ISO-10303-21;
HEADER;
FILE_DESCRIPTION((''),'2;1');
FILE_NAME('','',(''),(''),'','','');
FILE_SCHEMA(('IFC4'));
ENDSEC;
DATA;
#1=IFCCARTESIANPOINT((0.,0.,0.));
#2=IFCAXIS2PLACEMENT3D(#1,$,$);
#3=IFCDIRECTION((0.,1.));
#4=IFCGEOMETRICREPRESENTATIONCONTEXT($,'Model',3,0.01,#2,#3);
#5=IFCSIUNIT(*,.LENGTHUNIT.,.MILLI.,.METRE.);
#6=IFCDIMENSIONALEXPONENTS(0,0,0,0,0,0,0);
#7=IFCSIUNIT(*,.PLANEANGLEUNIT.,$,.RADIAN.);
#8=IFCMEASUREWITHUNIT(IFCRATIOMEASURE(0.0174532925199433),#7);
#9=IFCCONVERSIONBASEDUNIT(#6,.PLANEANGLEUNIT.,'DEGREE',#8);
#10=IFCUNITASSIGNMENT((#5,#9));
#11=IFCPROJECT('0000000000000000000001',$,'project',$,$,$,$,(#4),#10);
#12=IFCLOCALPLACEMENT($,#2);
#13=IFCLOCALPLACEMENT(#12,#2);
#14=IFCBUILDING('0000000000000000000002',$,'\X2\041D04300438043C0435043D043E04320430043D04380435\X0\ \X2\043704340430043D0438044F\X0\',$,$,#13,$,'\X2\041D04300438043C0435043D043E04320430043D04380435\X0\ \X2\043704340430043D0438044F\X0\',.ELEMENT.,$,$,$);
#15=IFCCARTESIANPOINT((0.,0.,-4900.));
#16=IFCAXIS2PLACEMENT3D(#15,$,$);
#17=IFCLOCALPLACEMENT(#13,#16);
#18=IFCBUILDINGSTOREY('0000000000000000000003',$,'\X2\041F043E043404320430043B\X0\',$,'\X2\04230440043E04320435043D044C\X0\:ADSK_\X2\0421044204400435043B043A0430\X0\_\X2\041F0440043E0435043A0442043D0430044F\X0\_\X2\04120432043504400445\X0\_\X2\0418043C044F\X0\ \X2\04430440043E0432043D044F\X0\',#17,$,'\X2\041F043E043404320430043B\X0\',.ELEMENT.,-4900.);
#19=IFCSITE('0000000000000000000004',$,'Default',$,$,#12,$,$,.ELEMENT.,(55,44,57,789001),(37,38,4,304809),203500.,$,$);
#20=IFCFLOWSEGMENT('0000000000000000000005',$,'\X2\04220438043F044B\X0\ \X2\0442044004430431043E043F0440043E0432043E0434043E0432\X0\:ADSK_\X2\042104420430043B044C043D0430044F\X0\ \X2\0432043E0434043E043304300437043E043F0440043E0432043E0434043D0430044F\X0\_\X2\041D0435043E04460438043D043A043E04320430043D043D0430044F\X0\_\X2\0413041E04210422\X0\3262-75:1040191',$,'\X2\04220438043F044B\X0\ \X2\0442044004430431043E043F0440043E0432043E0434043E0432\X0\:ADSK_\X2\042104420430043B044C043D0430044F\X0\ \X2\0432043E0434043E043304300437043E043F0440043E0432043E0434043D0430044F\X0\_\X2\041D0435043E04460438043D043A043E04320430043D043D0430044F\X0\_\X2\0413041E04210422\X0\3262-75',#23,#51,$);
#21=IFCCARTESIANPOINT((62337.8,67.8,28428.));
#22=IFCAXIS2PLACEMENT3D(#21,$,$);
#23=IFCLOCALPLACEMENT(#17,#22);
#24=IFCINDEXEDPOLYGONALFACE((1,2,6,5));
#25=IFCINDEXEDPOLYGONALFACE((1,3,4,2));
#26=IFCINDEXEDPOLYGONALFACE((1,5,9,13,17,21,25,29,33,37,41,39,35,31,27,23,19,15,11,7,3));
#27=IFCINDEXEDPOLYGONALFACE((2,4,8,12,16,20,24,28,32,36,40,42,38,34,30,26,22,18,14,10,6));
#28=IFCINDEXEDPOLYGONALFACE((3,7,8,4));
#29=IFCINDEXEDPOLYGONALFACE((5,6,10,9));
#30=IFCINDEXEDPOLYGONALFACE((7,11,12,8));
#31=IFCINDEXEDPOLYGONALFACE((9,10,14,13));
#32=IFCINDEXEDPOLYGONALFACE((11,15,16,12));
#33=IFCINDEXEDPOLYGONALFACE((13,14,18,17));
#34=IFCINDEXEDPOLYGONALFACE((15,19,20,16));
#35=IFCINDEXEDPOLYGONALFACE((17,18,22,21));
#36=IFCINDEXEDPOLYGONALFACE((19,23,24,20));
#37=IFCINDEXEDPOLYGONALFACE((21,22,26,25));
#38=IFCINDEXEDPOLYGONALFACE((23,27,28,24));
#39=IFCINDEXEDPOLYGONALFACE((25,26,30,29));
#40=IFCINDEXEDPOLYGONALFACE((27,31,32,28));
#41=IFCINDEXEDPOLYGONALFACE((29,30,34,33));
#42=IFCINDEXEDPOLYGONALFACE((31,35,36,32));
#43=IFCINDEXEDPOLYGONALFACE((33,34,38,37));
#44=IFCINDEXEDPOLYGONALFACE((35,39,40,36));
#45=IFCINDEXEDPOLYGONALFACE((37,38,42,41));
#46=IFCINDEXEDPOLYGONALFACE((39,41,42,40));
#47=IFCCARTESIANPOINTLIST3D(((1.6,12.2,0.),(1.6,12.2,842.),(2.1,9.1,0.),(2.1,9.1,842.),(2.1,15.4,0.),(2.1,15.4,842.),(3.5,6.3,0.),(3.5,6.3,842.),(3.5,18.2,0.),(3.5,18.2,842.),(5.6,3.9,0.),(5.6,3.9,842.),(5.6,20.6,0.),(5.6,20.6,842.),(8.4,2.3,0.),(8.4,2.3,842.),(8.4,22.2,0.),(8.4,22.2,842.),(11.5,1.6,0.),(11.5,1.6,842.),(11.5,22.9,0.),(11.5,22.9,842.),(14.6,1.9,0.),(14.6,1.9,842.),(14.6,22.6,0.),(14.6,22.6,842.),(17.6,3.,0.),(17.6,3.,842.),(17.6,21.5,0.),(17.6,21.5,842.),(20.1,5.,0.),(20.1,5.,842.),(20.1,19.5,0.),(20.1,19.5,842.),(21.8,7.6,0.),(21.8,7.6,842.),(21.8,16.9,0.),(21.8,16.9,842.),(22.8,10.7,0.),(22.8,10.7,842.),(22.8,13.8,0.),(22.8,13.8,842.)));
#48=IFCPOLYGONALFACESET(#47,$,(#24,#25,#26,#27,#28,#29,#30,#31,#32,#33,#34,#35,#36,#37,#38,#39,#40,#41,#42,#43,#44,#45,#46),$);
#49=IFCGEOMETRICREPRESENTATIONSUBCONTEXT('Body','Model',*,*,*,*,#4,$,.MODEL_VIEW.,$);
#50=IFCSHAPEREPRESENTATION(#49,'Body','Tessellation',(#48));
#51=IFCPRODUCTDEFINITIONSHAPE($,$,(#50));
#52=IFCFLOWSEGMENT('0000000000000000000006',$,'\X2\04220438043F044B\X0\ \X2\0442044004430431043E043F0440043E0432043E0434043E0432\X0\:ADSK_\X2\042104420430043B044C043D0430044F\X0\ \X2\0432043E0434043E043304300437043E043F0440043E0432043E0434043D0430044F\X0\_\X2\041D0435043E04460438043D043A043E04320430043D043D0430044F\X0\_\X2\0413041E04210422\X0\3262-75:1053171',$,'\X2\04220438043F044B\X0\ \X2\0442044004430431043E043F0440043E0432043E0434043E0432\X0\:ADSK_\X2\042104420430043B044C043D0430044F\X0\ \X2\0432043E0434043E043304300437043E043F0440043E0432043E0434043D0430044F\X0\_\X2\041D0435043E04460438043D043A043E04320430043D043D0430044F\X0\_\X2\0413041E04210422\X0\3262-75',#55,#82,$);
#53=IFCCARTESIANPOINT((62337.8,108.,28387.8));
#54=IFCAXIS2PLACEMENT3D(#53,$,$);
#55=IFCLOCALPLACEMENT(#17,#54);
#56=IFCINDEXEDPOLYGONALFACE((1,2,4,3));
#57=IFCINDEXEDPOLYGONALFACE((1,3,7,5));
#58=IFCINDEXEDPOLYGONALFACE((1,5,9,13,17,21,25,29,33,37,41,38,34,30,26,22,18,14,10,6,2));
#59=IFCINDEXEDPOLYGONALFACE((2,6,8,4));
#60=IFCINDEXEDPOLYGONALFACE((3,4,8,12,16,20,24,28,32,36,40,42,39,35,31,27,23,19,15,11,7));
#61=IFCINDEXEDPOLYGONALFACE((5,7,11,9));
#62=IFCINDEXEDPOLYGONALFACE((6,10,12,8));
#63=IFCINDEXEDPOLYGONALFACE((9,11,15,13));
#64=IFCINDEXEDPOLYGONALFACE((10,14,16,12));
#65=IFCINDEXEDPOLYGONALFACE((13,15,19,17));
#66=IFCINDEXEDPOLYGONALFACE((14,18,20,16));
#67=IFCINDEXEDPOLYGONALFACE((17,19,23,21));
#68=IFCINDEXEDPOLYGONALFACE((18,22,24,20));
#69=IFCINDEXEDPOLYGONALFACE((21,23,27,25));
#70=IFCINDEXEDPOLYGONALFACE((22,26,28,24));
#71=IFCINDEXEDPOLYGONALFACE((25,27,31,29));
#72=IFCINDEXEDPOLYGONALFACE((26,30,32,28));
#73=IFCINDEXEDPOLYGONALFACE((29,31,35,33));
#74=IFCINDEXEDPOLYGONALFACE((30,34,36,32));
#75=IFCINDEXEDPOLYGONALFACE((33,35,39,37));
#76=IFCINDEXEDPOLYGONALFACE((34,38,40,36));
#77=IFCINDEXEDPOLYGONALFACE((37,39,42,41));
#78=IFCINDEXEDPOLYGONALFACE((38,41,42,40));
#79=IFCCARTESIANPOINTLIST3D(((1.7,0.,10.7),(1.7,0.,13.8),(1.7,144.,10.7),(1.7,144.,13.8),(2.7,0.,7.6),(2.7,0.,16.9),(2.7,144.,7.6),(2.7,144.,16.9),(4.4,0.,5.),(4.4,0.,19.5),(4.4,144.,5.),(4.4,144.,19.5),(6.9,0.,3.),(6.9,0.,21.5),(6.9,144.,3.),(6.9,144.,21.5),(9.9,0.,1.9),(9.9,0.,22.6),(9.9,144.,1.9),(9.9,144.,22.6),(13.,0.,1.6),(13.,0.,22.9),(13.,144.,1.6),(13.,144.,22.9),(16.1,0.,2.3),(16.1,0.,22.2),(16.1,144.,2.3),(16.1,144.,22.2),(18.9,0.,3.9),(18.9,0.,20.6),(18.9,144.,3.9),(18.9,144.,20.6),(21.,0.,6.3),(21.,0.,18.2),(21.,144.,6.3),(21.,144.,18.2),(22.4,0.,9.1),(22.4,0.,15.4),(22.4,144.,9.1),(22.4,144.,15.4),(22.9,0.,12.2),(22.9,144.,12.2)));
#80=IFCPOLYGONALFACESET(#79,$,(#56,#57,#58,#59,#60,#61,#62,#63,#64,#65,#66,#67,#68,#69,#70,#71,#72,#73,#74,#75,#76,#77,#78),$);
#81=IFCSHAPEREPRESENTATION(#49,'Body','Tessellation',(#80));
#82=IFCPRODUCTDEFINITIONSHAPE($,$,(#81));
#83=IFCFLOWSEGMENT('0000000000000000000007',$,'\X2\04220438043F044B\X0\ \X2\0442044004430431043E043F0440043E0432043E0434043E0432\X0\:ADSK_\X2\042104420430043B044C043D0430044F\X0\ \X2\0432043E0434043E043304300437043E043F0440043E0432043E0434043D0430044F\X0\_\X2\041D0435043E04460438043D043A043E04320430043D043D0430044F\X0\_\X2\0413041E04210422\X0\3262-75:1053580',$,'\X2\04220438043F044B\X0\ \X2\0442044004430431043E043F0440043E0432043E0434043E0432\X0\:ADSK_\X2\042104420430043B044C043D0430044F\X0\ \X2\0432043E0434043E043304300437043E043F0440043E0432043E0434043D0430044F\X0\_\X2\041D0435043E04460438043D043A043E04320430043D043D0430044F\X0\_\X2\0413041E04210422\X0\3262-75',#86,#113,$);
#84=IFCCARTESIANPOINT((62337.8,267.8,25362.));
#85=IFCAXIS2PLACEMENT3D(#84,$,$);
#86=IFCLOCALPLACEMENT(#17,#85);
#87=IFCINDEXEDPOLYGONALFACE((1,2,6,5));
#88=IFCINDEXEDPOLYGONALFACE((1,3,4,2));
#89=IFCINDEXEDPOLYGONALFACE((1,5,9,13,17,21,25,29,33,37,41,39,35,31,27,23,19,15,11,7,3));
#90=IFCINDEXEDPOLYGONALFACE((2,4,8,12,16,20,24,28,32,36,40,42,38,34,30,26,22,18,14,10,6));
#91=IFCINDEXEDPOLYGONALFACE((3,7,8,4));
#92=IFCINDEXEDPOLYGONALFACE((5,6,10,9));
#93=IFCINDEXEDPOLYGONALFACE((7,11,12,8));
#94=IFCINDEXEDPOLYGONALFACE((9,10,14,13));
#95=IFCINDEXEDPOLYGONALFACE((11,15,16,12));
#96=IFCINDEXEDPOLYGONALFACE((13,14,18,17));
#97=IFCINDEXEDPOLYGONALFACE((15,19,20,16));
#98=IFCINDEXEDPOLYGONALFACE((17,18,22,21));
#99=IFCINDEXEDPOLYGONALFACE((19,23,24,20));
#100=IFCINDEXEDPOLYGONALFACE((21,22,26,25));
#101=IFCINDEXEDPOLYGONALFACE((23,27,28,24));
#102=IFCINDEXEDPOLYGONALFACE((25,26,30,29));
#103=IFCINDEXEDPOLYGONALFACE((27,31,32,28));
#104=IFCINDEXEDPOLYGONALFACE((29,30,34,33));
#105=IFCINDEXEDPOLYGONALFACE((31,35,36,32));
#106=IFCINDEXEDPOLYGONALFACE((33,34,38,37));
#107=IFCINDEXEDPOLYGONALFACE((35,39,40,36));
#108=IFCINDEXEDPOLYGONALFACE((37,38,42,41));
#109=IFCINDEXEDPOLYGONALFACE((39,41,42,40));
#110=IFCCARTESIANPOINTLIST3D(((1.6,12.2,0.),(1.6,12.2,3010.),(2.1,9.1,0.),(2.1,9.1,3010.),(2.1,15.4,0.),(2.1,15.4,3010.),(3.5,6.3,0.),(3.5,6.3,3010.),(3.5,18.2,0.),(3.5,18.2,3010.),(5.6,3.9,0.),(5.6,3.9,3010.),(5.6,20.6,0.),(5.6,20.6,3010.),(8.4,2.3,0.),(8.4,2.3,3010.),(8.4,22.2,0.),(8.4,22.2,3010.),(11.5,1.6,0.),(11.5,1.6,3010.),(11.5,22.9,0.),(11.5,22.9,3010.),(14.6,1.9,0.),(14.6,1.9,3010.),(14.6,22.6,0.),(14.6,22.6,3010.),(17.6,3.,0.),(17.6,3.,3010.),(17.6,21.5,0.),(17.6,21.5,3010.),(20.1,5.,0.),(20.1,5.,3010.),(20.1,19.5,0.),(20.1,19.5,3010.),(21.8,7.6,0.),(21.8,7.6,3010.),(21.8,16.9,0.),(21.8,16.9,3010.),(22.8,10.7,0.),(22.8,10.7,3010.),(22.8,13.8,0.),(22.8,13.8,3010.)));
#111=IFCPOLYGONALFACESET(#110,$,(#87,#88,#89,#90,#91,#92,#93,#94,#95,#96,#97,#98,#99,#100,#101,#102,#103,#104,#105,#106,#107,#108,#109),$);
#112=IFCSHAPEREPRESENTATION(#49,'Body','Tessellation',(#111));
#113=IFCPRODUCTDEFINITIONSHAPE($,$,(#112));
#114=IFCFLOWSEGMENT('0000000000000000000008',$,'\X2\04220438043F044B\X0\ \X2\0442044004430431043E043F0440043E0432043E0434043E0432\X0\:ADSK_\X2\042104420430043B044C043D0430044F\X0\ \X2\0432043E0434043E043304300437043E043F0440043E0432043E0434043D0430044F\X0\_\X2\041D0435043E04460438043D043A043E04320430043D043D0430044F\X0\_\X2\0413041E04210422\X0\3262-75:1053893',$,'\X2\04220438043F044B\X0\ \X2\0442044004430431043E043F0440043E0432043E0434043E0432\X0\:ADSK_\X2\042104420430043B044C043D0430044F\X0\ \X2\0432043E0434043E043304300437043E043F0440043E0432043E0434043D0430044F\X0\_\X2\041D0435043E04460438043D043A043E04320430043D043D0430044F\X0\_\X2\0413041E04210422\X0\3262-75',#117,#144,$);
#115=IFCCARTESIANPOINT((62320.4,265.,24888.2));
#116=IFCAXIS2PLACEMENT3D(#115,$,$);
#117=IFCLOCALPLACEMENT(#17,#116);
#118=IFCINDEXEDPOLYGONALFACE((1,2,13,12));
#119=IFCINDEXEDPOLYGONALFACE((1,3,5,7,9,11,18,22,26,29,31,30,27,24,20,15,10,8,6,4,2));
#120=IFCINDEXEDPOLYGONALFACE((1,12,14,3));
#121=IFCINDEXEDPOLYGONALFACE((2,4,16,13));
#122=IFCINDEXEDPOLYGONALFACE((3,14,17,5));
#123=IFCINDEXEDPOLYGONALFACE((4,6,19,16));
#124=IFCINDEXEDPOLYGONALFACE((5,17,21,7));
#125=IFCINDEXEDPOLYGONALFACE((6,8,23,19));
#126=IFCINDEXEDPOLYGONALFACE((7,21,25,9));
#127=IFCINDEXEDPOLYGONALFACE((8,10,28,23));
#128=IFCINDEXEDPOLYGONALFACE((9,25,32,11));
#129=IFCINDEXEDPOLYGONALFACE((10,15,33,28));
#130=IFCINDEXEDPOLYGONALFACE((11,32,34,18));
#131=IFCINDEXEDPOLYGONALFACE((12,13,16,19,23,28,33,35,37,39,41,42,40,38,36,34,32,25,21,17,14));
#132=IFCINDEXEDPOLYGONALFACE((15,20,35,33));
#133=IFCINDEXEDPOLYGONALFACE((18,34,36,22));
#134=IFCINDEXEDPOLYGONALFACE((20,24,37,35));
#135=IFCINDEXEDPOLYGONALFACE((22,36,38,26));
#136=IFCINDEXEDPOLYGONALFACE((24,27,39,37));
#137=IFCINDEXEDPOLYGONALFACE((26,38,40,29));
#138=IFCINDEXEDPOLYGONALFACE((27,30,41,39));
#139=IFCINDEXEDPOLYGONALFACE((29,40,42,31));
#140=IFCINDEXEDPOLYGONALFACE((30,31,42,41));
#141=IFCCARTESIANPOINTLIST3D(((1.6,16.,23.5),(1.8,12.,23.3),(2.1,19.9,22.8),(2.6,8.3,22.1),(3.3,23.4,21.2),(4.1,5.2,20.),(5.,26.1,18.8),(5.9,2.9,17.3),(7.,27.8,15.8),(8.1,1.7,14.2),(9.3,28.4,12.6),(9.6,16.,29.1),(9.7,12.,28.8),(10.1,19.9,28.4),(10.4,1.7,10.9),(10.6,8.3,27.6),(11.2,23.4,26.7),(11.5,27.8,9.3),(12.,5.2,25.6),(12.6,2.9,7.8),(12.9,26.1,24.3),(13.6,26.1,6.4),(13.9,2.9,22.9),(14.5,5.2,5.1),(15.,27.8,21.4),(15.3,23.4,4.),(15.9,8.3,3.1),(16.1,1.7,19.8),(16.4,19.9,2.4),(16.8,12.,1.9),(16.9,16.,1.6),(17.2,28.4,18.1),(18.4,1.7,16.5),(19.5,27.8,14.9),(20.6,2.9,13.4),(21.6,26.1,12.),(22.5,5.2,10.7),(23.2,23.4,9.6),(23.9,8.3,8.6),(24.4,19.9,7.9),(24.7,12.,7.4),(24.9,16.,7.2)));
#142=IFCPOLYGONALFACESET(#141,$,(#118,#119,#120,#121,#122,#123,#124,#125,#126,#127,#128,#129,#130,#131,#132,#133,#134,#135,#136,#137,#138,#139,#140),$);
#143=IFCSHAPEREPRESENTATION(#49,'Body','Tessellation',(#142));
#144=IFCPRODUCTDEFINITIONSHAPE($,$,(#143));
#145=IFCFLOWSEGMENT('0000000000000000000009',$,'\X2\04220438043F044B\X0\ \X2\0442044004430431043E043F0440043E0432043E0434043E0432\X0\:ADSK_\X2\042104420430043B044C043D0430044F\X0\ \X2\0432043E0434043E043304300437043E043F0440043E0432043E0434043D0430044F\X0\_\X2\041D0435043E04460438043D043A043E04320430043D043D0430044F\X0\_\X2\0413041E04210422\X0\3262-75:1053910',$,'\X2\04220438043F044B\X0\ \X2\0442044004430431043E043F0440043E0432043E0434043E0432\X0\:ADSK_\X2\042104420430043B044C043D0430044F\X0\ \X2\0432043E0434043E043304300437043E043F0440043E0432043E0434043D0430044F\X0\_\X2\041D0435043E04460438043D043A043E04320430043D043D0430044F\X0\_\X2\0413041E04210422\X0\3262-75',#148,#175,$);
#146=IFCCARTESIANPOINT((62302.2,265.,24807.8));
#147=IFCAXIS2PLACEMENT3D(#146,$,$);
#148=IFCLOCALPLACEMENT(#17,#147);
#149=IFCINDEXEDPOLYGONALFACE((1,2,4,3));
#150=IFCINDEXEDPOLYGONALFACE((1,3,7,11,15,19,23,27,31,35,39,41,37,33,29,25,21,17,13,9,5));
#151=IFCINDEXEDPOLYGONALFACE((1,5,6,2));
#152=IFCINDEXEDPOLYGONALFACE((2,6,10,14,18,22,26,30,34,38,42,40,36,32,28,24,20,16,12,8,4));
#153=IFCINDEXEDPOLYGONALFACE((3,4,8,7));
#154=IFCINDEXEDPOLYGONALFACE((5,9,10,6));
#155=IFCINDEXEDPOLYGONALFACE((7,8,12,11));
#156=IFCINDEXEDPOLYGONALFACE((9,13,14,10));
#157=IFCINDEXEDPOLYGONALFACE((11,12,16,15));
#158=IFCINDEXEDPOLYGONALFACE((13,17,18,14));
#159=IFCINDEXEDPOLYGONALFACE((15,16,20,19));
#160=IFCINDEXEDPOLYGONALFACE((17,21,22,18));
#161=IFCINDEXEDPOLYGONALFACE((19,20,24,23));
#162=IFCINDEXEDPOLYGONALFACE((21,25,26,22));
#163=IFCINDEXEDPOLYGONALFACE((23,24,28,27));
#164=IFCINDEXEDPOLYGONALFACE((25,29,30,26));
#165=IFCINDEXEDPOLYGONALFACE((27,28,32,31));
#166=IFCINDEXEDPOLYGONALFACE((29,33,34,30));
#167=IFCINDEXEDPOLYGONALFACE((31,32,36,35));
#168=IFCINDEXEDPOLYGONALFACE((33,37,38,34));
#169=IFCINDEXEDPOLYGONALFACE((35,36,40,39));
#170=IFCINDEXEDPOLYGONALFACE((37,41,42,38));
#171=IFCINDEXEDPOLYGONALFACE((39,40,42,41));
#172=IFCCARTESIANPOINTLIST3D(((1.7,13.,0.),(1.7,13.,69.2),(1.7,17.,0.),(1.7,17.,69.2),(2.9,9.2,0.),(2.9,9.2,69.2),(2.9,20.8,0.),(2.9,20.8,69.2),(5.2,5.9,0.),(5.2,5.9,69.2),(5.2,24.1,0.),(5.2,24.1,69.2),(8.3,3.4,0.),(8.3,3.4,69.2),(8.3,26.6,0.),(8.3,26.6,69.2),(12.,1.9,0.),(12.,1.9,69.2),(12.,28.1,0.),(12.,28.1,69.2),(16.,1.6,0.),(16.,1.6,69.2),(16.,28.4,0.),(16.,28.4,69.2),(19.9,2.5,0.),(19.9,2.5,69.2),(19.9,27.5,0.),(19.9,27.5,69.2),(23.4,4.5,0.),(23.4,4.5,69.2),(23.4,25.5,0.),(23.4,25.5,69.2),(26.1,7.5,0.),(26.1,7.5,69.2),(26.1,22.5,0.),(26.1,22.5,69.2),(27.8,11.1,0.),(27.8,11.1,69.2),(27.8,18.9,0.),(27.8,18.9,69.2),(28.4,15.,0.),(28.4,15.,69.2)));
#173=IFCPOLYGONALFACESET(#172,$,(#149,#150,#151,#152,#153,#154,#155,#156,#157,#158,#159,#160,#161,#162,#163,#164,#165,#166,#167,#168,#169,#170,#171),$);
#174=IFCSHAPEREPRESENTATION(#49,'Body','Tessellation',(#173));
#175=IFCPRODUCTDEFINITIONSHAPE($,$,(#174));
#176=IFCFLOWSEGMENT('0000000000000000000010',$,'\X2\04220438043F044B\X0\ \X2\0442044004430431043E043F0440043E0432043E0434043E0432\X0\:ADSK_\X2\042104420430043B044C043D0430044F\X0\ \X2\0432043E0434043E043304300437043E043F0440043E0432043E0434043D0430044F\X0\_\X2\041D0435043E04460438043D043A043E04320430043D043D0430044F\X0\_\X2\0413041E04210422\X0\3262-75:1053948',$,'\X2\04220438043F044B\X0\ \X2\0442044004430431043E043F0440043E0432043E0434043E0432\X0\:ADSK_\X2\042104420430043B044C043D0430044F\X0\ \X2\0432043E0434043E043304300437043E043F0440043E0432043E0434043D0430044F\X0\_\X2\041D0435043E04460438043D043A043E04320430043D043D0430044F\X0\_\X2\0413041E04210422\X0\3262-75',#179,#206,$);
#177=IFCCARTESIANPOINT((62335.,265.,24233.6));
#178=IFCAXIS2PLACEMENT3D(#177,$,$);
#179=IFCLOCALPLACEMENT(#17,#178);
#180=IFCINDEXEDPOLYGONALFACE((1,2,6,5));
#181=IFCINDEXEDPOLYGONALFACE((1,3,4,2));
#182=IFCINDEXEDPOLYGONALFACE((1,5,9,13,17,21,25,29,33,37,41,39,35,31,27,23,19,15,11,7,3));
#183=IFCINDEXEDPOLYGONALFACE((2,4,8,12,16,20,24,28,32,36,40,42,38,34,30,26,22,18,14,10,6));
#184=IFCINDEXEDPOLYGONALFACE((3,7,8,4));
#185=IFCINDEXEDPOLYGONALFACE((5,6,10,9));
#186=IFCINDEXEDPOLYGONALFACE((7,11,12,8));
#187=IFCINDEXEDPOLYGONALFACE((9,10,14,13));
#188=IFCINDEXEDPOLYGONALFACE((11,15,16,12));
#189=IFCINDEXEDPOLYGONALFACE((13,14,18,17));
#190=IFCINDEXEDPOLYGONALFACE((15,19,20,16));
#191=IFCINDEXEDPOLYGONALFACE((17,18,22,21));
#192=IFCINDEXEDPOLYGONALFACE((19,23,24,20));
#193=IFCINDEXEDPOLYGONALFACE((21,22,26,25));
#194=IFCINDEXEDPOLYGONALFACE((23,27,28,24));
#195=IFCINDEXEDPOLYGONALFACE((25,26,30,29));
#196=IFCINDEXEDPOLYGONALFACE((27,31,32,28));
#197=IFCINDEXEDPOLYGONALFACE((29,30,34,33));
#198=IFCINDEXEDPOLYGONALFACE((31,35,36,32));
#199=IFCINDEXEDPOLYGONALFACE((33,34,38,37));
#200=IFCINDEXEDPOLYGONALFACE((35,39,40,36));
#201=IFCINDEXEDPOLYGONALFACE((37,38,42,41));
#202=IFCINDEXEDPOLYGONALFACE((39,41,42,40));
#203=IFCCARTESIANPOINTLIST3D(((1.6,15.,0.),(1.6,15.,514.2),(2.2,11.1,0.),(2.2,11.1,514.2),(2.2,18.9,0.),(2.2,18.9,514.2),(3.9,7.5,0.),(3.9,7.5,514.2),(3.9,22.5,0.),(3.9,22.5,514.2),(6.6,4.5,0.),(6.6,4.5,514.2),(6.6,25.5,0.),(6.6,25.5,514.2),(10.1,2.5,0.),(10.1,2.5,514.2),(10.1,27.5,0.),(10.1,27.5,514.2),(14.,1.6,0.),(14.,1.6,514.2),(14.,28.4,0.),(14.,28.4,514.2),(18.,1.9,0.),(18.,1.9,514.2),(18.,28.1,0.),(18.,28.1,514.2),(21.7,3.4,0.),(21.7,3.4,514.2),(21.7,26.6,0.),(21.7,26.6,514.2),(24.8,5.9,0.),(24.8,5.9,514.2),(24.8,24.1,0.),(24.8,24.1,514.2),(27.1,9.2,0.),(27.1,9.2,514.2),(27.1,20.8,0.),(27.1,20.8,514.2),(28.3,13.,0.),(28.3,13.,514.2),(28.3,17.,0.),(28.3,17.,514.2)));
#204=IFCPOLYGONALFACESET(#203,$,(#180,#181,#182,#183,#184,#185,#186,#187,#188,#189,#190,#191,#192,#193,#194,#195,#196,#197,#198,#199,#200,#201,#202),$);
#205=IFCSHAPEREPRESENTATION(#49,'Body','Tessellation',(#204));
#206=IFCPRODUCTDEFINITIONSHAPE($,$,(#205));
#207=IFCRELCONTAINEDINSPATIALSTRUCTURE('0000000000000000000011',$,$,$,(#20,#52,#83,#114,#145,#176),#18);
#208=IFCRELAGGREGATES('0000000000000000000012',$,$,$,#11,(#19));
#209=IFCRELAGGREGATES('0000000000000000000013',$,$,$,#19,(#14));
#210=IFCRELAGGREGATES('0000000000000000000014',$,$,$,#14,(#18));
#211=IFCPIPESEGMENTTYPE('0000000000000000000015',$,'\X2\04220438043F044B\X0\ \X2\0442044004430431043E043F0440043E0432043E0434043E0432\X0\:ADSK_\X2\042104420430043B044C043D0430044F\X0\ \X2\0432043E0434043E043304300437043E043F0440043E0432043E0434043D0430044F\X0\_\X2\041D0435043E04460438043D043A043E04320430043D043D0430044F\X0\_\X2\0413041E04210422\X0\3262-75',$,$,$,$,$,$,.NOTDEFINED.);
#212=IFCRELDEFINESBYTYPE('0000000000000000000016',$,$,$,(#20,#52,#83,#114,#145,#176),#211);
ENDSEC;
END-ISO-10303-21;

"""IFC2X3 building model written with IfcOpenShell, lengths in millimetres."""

from ifc_helpers import new_model, entity, si_unit, converted_unit, direction, frame, origin, origin_2d_with_axis, place, context, subcontext, project, spatial, circle, extrude, type_object, element, save


model = new_model("IFC2X3")

# Units and contexts
model_context = context("Model", 3, precision=0.01, world=origin(), true_north=direction((0.0, 1.0)))
body_context = subcontext(model_context, "Body", "Model", "MODEL_VIEW")
ifc_project = project(units=[si_unit("LENGTHUNIT", "METRE", prefix="MILLI"), converted_unit("PLANEANGLEUNIT", "DEGREE", entity("IfcRatioMeasure", 0.0174532925199433), si_unit("PLANEANGLEUNIT", "RADIAN"), dimensions=[0, 0, 0, 0, 0, 0, 0])], contexts=[model_context])

# Site, building, storey
site_placement = place(None, origin())
site = spatial("IfcSite", under=ifc_project, at=site_placement, Name="Default", CompositionType="ELEMENT", RefLatitude=(55, 44, 57, 789001), RefLongitude=(37, 38, 4, 304809), RefElevation=203500.0)
building_placement = place(site_placement, origin())
building = spatial("IfcBuilding", under=site, at=building_placement, Name="Наименование здания", LongName="Наименование здания", CompositionType="ELEMENT")
storey_placement = place(building_placement, frame((0.0, 0.0, -4900.0)))
storey = spatial("IfcBuildingStorey", under=building, at=storey_placement, Name="Подвал", ObjectType="Уровень:ADSK_Стрелка_Проектная_Вверх_Имя уровня", LongName="Подвал", CompositionType="ELEMENT", Elevation=-4900.0)

# Flow segments
pipe_segment_type = type_object("IfcPipeSegmentType", Name="Типы трубопроводов:ADSK_Стальная водогазопроводная_Неоцинкованная_ГОСТ3262-75", PredefinedType="NOTDEFINED")
flow_segment_1_placement = place(storey_placement, frame((62337.8, 67.8, 28428.0)))
element("IfcFlowSegment", 1, at=flow_segment_1_placement, inside=storey, type_object=pipe_segment_type, Name="Типы трубопроводов:ADSK_Стальная водогазопроводная_Неоцинкованная_ГОСТ3262-75:1040191", ObjectType="Типы трубопроводов:ADSK_Стальная водогазопроводная_Неоцинкованная_ГОСТ3262-75", context=body_context, shape_type="SweptSolid", body=[
    extrude(circle(Radius=10.7, at=origin_2d_with_axis()), frame((12.2, 12.2, 0.0), z_axis=(0.0, 0.0, 1.0), x_axis=(-1.0, 0.0, 0.0)), (0.0, 0.0, 1.0), 842.0),
])
flow_segment_2_placement = place(storey_placement, frame((62337.8, 108.0, 28387.8)))
element("IfcFlowSegment", 2, at=flow_segment_2_placement, inside=storey, type_object=pipe_segment_type, Name="Типы трубопроводов:ADSK_Стальная водогазопроводная_Неоцинкованная_ГОСТ3262-75:1053171", ObjectType="Типы трубопроводов:ADSK_Стальная водогазопроводная_Неоцинкованная_ГОСТ3262-75", context=body_context, shape_type="SweptSolid", body=[
    extrude(circle(Radius=10.7, at=origin_2d_with_axis()), frame((12.2, 0.0, 12.2), z_axis=(0.0, 1.0, 0.0), x_axis=(1.0, 0.0, 0.0)), (0.0, 0.0, 1.0), 144.0),
])
flow_segment_3_placement = place(storey_placement, frame((62337.8, 267.8, 25362.0)))
element("IfcFlowSegment", 3, at=flow_segment_3_placement, inside=storey, type_object=pipe_segment_type, Name="Типы трубопроводов:ADSK_Стальная водогазопроводная_Неоцинкованная_ГОСТ3262-75:1053580", ObjectType="Типы трубопроводов:ADSK_Стальная водогазопроводная_Неоцинкованная_ГОСТ3262-75", context=body_context, shape_type="SweptSolid", body=[
    extrude(circle(Radius=10.7, at=origin_2d_with_axis()), frame((12.2, 12.2, 0.0), z_axis=(0.0, 0.0, 1.0), x_axis=(-1.0, 0.0, 0.0)), (0.0, 0.0, 1.0), 3010.0),
])
flow_segment_4_placement = place(storey_placement, frame((62320.4, 265.0, 24888.2)))
element("IfcFlowSegment", 4, at=flow_segment_4_placement, inside=storey, type_object=pipe_segment_type, Name="Типы трубопроводов:ADSK_Стальная водогазопроводная_Неоцинкованная_ГОСТ3262-75:1053893", ObjectType="Типы трубопроводов:ADSK_Стальная водогазопроводная_Неоцинкованная_ГОСТ3262-75", context=body_context, shape_type="SweptSolid", body=[
    extrude(circle(Radius=13.4, at=origin_2d_with_axis()), frame((9.3, 15.0, 12.6), z_axis=(0.819152, 0.0, 0.573576), x_axis=(0.0, 1.0, 0.0)), (0.0, 0.0, 1.0), 9.7),
])
flow_segment_5_placement = place(storey_placement, frame((62302.2, 265.0, 24807.8)))
element("IfcFlowSegment", 5, at=flow_segment_5_placement, inside=storey, type_object=pipe_segment_type, Name="Типы трубопроводов:ADSK_Стальная водогазопроводная_Неоцинкованная_ГОСТ3262-75:1053910", ObjectType="Типы трубопроводов:ADSK_Стальная водогазопроводная_Неоцинкованная_ГОСТ3262-75", context=body_context, shape_type="SweptSolid", body=[
    extrude(circle(Radius=13.4, at=origin_2d_with_axis()), frame((15.0, 15.0, 0.0)), (0.0, 0.0, 1.0), 69.2),
])
flow_segment_6_placement = place(storey_placement, frame((62335.0, 265.0, 24233.6)))
element("IfcFlowSegment", 6, at=flow_segment_6_placement, inside=storey, type_object=pipe_segment_type, Name="Типы трубопроводов:ADSK_Стальная водогазопроводная_Неоцинкованная_ГОСТ3262-75:1053948", ObjectType="Типы трубопроводов:ADSK_Стальная водогазопроводная_Неоцинкованная_ГОСТ3262-75", context=body_context, shape_type="SweptSolid", body=[
    extrude(circle(Radius=13.4, at=origin_2d_with_axis()), frame((15.0, 15.0, 0.0), z_axis=(0.0, 0.0, 1.0), x_axis=(-1.0, 0.0, 0.0)), (0.0, 0.0, 1.0), 514.2),
])

save(model, "model.ifc")
